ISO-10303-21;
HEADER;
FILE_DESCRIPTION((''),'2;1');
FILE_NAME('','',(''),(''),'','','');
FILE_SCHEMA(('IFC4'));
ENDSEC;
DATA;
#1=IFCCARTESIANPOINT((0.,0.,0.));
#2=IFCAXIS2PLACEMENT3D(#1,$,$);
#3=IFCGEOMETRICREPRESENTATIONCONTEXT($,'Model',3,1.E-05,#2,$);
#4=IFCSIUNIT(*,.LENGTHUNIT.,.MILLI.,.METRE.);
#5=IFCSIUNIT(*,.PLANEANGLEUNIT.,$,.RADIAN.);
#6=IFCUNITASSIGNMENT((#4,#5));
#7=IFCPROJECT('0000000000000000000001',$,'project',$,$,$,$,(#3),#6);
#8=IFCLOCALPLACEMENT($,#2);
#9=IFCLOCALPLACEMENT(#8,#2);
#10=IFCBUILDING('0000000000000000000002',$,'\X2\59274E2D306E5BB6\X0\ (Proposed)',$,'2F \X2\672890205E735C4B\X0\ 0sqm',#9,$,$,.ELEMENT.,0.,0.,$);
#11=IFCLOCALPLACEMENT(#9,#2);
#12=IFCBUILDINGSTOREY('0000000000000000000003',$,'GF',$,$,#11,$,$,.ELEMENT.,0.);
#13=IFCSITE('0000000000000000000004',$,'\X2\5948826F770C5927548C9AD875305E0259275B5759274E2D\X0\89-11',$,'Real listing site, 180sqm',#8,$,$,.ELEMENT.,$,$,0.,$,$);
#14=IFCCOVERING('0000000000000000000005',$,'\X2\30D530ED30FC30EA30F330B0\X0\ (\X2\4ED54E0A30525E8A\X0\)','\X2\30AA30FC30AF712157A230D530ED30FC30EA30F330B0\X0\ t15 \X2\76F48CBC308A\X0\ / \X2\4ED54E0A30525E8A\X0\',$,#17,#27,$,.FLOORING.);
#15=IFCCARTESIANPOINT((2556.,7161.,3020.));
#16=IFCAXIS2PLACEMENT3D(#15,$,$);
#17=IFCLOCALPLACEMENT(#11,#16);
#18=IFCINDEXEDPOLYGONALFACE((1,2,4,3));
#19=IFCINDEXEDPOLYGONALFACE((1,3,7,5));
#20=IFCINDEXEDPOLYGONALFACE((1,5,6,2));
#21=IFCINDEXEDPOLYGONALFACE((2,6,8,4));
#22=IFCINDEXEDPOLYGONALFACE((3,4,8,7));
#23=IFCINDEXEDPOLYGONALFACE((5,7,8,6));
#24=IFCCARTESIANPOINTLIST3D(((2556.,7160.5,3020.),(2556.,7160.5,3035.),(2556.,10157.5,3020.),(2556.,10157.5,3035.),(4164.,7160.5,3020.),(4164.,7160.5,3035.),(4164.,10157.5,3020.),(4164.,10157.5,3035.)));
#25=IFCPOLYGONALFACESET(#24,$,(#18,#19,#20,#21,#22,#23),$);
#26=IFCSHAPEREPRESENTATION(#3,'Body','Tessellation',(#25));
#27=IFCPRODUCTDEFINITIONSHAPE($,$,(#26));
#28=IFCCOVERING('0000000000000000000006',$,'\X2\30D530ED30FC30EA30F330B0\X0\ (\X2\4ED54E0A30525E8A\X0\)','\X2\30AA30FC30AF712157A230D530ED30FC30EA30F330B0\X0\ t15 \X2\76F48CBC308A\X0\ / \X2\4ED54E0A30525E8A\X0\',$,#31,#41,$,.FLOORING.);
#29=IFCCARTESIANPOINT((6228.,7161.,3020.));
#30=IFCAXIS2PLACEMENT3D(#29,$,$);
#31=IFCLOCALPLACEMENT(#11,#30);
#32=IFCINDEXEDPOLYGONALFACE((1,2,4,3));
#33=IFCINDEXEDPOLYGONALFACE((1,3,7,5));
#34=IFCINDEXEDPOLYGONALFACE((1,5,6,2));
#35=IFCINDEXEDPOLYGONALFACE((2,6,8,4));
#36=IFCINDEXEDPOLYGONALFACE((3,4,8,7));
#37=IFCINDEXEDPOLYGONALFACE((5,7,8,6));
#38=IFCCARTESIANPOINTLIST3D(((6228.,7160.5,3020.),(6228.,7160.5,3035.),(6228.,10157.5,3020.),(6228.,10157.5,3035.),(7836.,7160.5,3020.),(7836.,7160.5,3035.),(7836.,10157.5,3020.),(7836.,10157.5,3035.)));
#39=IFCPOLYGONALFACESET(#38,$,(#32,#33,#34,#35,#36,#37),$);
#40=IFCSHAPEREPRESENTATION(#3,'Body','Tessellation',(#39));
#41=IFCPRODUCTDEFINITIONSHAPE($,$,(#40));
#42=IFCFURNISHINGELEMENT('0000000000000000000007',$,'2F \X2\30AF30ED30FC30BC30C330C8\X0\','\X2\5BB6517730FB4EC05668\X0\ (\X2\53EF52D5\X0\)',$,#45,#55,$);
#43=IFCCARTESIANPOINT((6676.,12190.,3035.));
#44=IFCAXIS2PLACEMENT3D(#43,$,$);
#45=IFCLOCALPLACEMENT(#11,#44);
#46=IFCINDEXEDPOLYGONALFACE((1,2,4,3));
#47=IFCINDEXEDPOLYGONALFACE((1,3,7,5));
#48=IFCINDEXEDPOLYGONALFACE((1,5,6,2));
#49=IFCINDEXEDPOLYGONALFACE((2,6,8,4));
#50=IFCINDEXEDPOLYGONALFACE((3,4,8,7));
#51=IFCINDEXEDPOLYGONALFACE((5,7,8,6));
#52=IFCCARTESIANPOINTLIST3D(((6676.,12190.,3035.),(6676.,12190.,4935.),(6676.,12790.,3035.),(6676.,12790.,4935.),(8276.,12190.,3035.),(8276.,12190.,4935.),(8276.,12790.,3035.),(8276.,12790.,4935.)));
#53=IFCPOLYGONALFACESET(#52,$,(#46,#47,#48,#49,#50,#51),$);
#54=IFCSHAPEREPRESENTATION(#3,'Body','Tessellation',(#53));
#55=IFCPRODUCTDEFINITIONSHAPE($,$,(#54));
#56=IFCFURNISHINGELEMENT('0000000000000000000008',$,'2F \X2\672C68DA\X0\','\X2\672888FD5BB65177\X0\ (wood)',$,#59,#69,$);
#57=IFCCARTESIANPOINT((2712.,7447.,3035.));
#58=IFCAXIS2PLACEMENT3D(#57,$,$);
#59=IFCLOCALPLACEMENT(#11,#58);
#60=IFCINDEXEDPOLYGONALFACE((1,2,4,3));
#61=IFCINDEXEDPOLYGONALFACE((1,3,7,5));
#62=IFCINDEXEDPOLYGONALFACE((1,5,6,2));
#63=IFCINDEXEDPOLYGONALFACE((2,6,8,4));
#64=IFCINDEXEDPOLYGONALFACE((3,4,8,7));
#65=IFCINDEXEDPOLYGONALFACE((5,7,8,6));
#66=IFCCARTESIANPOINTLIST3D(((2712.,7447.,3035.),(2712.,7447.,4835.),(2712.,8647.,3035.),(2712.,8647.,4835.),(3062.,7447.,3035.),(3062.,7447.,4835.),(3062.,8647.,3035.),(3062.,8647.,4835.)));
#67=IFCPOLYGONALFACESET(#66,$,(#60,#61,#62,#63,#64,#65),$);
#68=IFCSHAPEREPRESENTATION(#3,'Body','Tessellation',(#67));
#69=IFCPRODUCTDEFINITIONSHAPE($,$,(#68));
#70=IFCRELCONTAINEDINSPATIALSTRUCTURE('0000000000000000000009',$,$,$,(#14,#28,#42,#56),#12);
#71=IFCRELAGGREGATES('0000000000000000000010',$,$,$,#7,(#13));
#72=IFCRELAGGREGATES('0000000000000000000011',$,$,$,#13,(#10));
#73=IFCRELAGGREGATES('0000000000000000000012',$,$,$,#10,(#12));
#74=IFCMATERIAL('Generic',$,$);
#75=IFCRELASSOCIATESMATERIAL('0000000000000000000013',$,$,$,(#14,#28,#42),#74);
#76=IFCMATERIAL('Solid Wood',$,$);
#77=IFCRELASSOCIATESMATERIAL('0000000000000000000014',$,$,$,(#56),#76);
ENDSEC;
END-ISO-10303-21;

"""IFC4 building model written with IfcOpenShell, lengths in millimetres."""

from ifc_helpers import new_model, si_unit, frame, frame_2d, origin, place, context, project, spatial, rectangle, extrude, material, element, save


model = new_model("IFC4")

# Units and contexts
model_context = context("Model", 3, precision=1e-05, world=origin())
ifc_project = project(units=[si_unit("LENGTHUNIT", "METRE", prefix="MILLI"), si_unit("PLANEANGLEUNIT", "RADIAN")], contexts=[model_context])

# Site, building, storey
site_placement = place(None, origin())
site = spatial("IfcSite", under=ifc_project, at=site_placement, Name="奈良県大和高田市大字大中89-11", ObjectType="Real listing site, 180sqm", CompositionType="ELEMENT", RefElevation=0.0)
building_placement = place(site_placement, origin())
building = spatial("IfcBuilding", under=site, at=building_placement, Name="大中の家 (Proposed)", ObjectType="2F 木造平屋 0sqm", CompositionType="ELEMENT", ElevationOfRefHeight=0.0, ElevationOfTerrain=0.0)
storey_placement = place(building_placement, origin())
storey = spatial("IfcBuildingStorey", under=building, at=storey_placement, Name="GF", CompositionType="ELEMENT", Elevation=0.0)

# Shared definitions
ifc_material_1 = material(Name="Solid Wood")

# Coverings
ifc_material_2 = material(Name="Generic")
covering_1_placement = place(storey_placement, frame((2556.0, 7161.0, 3020.0)))
element("IfcCovering", 1, at=covering_1_placement, inside=storey, material=ifc_material_2, Name="フローリング (仕上げ床)", Description="オーク無垢フローリング t15 直貼り / 仕上げ床", PredefinedType="FLOORING", context=model_context, shape_type="SweptSolid", body=[
    extrude(rectangle(XDim=1608.0, YDim=2997.0, at=frame_2d((804.0, 1498.0))), frame((2556.0, 7161.0, 3020.0)), (0.0, 0.0, 1.0), 15.0),
])
covering_2_placement = place(storey_placement, frame((6228.0, 7161.0, 3020.0)))
element("IfcCovering", 2, at=covering_2_placement, inside=storey, material=ifc_material_2, Name="フローリング (仕上げ床)", Description="オーク無垢フローリング t15 直貼り / 仕上げ床", PredefinedType="FLOORING", context=model_context, shape_type="SweptSolid", body=[
    extrude(rectangle(XDim=1608.0, YDim=2997.0, at=frame_2d((804.0, 1498.0))), frame((6228.0, 7161.0, 3020.0)), (0.0, 0.0, 1.0), 15.0),
])

# Furnishing elements
furnishing_1_placement = place(storey_placement, frame((6676.0, 12190.0, 3035.0)))
element("IfcFurnishingElement", 3, at=furnishing_1_placement, inside=storey, material=ifc_material_2, Name="2F クローゼット", Description="家具・什器 (可動)", context=model_context, shape_type="SweptSolid", body=[
    extrude(rectangle(XDim=1600.0, YDim=600.0, at=frame_2d((800.0, 300.0))), frame((6676.0, 12190.0, 3035.0)), (0.0, 0.0, 1.0), 1900.0),
])
furnishing_2_placement = place(storey_placement, frame((2712.0, 7447.0, 3035.0)))
element("IfcFurnishingElement", 4, at=furnishing_2_placement, inside=storey, material=ifc_material_1, Name="2F 本棚", Description="木製家具 (wood)", context=model_context, shape_type="SweptSolid", body=[
    extrude(rectangle(XDim=350.0, YDim=1200.0, at=frame_2d((175.0, 600.0))), frame((2712.0, 7447.0, 3035.0)), (0.0, 0.0, 1.0), 1800.0),
])

save(model, "model.ifc")
